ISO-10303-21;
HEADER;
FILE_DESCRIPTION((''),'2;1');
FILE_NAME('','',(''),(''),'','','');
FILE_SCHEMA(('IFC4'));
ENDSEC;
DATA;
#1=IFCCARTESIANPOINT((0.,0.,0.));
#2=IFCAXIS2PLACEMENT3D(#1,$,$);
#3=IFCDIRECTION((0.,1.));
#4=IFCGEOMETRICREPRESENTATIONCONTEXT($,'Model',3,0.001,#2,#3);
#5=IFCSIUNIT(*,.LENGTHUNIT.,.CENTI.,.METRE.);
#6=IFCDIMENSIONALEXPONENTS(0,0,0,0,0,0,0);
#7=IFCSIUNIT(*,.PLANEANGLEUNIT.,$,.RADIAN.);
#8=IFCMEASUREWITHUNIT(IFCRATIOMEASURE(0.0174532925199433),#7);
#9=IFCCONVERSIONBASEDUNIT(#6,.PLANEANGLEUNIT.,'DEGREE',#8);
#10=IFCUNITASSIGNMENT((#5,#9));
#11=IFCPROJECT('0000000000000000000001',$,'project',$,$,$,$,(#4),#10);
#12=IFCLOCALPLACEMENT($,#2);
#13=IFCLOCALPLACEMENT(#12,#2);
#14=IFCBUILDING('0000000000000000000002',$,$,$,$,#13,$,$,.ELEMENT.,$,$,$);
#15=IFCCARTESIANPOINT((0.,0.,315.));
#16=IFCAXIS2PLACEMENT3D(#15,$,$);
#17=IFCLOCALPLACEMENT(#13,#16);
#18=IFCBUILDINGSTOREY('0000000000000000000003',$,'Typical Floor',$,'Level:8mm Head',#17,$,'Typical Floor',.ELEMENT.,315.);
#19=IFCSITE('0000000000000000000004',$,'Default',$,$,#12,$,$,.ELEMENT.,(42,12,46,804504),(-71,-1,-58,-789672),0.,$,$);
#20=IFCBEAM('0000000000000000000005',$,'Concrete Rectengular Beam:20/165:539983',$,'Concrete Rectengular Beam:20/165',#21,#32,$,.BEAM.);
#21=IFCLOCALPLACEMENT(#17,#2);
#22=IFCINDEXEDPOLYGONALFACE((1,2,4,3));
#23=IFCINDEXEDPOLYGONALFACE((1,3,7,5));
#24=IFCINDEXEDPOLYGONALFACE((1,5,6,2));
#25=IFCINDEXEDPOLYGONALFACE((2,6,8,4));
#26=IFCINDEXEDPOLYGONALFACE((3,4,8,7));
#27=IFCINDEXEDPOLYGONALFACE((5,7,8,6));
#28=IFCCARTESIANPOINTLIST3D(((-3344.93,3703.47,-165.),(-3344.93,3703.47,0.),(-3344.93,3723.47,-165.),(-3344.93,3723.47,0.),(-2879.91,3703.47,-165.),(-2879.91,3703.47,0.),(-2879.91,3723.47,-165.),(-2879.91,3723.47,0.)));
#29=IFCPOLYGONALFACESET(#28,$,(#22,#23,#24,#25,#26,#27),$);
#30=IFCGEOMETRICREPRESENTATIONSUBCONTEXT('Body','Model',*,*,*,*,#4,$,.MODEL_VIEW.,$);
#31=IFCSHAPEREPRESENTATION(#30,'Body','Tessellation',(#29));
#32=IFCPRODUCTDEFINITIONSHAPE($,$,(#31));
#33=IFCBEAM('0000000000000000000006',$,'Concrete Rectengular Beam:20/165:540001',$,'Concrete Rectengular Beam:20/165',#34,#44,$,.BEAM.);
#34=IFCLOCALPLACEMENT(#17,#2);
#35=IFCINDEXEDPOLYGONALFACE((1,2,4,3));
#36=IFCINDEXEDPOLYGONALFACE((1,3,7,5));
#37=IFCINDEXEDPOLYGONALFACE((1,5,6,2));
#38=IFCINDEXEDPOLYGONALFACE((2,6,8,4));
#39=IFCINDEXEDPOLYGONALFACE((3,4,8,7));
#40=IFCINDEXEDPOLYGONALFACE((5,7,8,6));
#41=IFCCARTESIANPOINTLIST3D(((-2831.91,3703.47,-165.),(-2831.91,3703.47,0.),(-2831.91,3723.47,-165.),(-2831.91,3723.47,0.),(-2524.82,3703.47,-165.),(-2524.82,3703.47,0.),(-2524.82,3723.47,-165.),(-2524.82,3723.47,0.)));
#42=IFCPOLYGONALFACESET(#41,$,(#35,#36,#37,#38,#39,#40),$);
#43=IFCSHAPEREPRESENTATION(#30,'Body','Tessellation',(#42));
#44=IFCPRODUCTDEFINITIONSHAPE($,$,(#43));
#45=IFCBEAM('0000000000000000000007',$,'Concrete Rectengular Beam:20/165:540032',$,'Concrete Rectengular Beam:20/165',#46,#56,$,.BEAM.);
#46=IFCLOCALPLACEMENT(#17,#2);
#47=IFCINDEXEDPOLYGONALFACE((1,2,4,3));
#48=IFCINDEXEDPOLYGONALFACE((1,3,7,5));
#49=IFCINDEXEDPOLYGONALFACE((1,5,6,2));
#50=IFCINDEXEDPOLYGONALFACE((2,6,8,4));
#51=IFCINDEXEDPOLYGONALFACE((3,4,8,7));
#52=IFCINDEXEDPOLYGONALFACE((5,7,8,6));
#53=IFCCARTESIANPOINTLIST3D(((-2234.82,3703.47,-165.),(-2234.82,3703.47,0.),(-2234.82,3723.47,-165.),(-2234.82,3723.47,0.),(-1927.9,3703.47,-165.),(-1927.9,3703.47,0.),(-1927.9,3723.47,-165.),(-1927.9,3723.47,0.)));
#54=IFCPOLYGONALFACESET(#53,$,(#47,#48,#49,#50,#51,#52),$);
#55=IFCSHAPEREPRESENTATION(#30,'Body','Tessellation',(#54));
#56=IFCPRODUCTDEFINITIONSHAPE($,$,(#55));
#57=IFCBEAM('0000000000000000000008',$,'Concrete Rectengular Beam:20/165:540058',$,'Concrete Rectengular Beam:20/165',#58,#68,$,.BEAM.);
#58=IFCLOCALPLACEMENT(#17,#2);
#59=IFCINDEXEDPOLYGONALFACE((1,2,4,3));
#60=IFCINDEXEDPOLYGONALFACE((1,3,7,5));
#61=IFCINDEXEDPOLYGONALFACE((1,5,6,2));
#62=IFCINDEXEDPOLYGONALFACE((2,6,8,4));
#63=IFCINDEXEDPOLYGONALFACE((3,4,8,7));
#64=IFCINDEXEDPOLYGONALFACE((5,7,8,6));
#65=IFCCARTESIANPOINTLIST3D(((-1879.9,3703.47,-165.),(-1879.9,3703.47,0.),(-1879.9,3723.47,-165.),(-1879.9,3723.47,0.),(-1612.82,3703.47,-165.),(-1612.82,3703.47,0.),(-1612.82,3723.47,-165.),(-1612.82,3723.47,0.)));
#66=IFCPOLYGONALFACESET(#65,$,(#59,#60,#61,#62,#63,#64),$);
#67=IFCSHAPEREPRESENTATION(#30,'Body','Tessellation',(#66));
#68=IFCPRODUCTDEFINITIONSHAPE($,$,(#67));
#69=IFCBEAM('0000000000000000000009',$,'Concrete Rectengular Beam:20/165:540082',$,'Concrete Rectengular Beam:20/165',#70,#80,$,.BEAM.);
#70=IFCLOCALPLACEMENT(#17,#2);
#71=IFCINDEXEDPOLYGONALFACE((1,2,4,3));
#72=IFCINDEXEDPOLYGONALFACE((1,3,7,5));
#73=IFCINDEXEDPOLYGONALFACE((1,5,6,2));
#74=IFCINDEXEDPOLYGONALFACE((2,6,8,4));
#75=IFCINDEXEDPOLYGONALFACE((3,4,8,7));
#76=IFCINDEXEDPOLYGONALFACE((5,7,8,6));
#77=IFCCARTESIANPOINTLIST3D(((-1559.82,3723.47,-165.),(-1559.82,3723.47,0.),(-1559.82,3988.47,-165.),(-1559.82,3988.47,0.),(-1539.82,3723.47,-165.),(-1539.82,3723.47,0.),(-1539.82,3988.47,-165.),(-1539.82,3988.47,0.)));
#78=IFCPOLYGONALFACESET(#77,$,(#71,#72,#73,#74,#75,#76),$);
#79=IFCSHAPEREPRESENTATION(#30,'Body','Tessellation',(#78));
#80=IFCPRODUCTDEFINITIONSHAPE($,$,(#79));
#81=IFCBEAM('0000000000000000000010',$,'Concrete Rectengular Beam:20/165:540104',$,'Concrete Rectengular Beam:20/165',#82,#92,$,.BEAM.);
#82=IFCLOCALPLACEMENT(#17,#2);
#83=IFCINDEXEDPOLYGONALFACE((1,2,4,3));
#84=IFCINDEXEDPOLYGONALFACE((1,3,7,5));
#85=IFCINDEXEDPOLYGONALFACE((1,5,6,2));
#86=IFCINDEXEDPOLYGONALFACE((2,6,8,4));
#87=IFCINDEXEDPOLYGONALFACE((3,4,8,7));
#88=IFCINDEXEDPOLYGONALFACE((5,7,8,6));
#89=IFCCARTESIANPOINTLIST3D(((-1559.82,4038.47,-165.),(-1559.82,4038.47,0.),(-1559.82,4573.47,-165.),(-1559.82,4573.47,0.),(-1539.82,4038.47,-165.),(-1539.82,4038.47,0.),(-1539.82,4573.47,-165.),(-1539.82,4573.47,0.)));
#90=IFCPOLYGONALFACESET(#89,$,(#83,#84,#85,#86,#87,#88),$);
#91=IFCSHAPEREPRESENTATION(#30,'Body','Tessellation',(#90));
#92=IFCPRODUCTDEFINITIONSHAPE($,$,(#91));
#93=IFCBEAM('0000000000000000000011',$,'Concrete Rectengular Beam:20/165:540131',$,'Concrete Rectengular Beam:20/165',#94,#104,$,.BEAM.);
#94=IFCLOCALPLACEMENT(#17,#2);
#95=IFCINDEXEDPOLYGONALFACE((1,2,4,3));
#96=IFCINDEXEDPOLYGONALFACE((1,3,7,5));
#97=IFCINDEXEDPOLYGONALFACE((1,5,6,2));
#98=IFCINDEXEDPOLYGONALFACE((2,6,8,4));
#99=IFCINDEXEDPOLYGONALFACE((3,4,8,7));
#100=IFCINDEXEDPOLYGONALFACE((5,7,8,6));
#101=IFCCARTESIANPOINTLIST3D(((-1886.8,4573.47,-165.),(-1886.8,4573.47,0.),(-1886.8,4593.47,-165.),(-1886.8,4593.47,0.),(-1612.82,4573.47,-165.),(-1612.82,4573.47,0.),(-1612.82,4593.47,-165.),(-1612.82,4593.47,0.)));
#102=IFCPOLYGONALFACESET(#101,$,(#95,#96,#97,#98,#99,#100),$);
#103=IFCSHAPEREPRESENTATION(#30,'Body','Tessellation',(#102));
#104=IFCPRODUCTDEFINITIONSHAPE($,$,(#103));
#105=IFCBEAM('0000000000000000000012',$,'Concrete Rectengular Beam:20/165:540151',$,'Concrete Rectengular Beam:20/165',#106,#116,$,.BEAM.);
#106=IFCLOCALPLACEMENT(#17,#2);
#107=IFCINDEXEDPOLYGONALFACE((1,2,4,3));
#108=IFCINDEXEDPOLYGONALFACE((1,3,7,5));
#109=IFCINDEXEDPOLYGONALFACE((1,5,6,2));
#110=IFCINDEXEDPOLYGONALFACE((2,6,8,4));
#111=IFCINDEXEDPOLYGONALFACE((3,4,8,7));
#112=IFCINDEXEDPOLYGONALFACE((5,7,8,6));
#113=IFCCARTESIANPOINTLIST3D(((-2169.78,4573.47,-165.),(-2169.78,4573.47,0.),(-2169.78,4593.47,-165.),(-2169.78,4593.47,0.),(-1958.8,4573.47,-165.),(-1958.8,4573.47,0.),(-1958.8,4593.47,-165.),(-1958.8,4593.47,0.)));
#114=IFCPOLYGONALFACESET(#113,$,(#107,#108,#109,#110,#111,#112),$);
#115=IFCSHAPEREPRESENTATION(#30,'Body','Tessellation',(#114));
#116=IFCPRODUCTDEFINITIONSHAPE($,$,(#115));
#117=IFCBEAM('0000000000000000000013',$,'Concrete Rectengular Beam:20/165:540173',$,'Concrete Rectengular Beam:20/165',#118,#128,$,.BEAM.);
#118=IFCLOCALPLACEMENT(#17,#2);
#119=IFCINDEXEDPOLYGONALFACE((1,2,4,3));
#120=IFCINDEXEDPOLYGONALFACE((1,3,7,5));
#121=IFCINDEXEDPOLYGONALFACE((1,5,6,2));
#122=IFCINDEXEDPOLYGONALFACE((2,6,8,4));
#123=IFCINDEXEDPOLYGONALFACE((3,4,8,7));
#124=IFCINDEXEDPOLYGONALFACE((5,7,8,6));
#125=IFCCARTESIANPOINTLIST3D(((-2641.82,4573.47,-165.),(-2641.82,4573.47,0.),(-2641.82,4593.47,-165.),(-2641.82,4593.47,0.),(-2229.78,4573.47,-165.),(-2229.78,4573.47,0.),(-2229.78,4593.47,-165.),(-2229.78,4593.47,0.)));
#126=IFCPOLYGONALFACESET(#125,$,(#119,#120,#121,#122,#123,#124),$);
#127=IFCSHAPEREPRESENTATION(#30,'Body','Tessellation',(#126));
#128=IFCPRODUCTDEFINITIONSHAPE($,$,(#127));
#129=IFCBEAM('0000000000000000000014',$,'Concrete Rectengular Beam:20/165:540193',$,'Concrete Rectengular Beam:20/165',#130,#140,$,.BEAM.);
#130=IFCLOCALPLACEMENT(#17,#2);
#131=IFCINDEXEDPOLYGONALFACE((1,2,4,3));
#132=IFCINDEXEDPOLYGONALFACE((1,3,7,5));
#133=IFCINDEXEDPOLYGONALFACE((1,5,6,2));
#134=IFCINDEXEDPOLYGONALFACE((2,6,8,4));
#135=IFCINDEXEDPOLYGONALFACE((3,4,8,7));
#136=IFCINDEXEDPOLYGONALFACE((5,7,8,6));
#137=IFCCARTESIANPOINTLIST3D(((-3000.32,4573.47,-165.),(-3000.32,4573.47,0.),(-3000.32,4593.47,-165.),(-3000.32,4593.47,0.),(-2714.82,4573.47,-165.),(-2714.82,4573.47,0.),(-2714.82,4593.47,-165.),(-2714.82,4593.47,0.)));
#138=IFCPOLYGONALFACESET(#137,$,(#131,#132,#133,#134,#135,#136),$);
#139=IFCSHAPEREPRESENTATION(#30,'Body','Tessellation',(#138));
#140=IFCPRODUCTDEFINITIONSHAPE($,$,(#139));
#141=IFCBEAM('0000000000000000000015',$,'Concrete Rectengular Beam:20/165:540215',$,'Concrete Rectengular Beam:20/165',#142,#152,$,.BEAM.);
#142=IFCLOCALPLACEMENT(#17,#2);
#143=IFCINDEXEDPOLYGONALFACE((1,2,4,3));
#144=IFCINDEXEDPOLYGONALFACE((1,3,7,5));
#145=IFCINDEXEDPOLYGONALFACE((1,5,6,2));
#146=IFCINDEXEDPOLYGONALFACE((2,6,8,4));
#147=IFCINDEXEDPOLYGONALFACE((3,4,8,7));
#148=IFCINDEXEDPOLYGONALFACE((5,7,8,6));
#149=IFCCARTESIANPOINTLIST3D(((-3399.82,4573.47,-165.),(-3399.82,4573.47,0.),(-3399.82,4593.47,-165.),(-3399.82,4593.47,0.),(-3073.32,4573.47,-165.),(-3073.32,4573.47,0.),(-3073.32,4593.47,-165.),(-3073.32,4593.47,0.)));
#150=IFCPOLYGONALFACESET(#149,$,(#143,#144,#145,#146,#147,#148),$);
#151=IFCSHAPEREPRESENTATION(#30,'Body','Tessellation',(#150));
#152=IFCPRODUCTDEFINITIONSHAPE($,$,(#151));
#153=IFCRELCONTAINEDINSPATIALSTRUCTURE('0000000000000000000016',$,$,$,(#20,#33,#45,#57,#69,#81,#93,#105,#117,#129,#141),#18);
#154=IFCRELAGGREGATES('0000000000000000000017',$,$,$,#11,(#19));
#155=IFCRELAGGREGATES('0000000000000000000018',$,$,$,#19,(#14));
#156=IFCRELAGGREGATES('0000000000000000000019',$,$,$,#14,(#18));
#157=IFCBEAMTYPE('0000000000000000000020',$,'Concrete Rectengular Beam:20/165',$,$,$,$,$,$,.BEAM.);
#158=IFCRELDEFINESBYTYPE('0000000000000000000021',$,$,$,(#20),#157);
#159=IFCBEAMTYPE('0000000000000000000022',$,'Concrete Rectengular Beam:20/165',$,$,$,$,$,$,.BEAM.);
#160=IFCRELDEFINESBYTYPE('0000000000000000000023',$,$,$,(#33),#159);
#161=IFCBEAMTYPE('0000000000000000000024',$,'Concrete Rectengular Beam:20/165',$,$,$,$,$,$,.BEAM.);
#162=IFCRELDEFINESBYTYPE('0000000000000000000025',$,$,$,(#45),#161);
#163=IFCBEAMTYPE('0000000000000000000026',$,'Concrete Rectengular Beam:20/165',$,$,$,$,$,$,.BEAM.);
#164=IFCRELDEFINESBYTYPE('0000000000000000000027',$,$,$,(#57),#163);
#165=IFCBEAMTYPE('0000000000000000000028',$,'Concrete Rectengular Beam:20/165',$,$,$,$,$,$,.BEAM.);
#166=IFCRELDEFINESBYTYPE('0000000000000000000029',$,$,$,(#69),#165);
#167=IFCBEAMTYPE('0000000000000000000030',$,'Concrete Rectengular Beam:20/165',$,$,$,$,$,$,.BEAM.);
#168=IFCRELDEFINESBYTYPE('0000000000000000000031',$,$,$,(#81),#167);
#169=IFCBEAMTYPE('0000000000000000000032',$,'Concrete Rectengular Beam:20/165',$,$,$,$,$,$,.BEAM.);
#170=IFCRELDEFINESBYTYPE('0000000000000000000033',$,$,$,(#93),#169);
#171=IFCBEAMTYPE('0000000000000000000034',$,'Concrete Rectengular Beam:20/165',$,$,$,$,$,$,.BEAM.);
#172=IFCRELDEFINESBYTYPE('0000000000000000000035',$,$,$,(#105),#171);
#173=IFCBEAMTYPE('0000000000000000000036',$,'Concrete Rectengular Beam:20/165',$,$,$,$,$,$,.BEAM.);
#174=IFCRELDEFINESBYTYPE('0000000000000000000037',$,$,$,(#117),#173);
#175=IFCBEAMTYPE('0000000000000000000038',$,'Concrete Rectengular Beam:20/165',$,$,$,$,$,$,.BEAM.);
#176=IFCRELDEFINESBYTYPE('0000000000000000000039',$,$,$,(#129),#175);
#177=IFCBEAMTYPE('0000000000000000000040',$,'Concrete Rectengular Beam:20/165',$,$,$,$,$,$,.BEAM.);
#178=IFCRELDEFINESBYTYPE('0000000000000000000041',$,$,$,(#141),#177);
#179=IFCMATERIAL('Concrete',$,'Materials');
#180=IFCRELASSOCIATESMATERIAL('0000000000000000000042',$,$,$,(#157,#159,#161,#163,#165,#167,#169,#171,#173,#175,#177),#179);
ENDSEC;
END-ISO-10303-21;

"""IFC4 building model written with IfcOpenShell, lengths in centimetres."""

from ifc_helpers import new_model, entity, si_unit, converted_unit, direction, frame, origin, place, context, subcontext, project, spatial, indexed_curve, outline, extrude, source, transform, mapped, material, type_object, type_shapes, element, save


model = new_model("IFC4")

# Units and contexts
model_context = context("Model", 3, precision=0.001, world=origin(), true_north=direction((0.0, 1.0)))
body_context = subcontext(model_context, "Body", "Model", "MODEL_VIEW")
ifc_project = project(units=[si_unit("LENGTHUNIT", "METRE", prefix="CENTI"), converted_unit("PLANEANGLEUNIT", "DEGREE", entity("IfcRatioMeasure", 0.0174532925199433), si_unit("PLANEANGLEUNIT", "RADIAN"), dimensions=[0, 0, 0, 0, 0, 0, 0])], contexts=[model_context])

# Site, building, storey
site_placement = place(None, origin())
site = spatial("IfcSite", under=ifc_project, at=site_placement, Name="Default", CompositionType="ELEMENT", RefLatitude=(42, 12, 46, 804504), RefLongitude=(-71, -1, -58, -789672), RefElevation=0.0)
building_placement = place(site_placement, origin())
building = spatial("IfcBuilding", under=site, at=building_placement, CompositionType="ELEMENT")
storey_placement = place(building_placement, frame((0.0, 0.0, 315.0)))
storey = spatial("IfcBuildingStorey", under=building, at=storey_placement, Name="Typical Floor", ObjectType="Level:8mm Head", LongName="Typical Floor", CompositionType="ELEMENT", Elevation=315.0)

# Beams
ifc_material = material(Name="Concrete", Category="Materials")
beam_type_1 = type_object("IfcBeamType", Name="Concrete Rectengular Beam:20/165", PredefinedType="BEAM", material=ifc_material)
shared_shape_1 = source(origin(), body_context, "Body", "SweptSolid", [
    extrude(outline(indexed_curve([(-82.5, -10.0), (82.5, -10.0), (82.5, 10.0), (-82.5, 10.0), (-82.5, -10.0)], self_intersect=False)), frame((-3344.93, 3713.47, 232.5), z_axis=(1.0, 0.0, 0.0), x_axis=(0.0, 0.0, -1.0)), (0.0, 0.0, 1.0), 465.02),
])
type_shapes(beam_type_1, [shared_shape_1])
beam_1_placement = place(storey_placement, frame((0.0, 0.0, -315.0)))
element("IfcBeam", 1, at=beam_1_placement, inside=storey, type_object=beam_type_1, Name="Concrete Rectengular Beam:20/165:539983", ObjectType="Concrete Rectengular Beam:20/165", PredefinedType="BEAM", context=body_context, shape_type="MappedRepresentation", body=[
    mapped(shared_shape_1, transform((0.0, 0.0, 0.0), scale=1.0)),
])
beam_type_2 = type_object("IfcBeamType", Name="Concrete Rectengular Beam:20/165", PredefinedType="BEAM", material=ifc_material)
shared_shape_2 = source(origin(), body_context, "Body", "SweptSolid", [
    extrude(outline(indexed_curve([(-82.5, -10.0), (82.5, -10.0), (82.5, 10.0), (-82.5, 10.0), (-82.5, -10.0)], self_intersect=False)), frame((-2831.91, 3713.47, 232.5), z_axis=(1.0, 0.0, 0.0), x_axis=(0.0, 0.0, -1.0)), (0.0, 0.0, 1.0), 307.09),
])
type_shapes(beam_type_2, [shared_shape_2])
beam_2_placement = place(storey_placement, frame((0.0, 0.0, -315.0)))
element("IfcBeam", 2, at=beam_2_placement, inside=storey, type_object=beam_type_2, Name="Concrete Rectengular Beam:20/165:540001", ObjectType="Concrete Rectengular Beam:20/165", PredefinedType="BEAM", context=body_context, shape_type="MappedRepresentation", body=[
    mapped(shared_shape_2, transform((0.0, 0.0, 0.0), scale=1.0)),
])
beam_type_3 = type_object("IfcBeamType", Name="Concrete Rectengular Beam:20/165", PredefinedType="BEAM", material=ifc_material)
shared_shape_3 = source(origin(), body_context, "Body", "SweptSolid", [
    extrude(outline(indexed_curve([(-82.5, -10.0), (82.5, -10.0), (82.5, 10.0), (-82.5, 10.0), (-82.5, -10.0)], self_intersect=False)), frame((-2234.82, 3713.47, 232.5), z_axis=(1.0, 0.0, 0.0), x_axis=(0.0, 0.0, -1.0)), (0.0, 0.0, 1.0), 306.92),
])
type_shapes(beam_type_3, [shared_shape_3])
beam_3_placement = place(storey_placement, frame((0.0, 0.0, -315.0)))
element("IfcBeam", 3, at=beam_3_placement, inside=storey, type_object=beam_type_3, Name="Concrete Rectengular Beam:20/165:540032", ObjectType="Concrete Rectengular Beam:20/165", PredefinedType="BEAM", context=body_context, shape_type="MappedRepresentation", body=[
    mapped(shared_shape_3, transform((0.0, 0.0, 0.0), scale=1.0)),
])
beam_type_4 = type_object("IfcBeamType", Name="Concrete Rectengular Beam:20/165", PredefinedType="BEAM", material=ifc_material)
shared_shape_4 = source(origin(), body_context, "Body", "SweptSolid", [
    extrude(outline(indexed_curve([(-82.5, -10.0), (82.5, -10.0), (82.5, 10.0), (-82.5, 10.0), (-82.5, -10.0)], self_intersect=False)), frame((-1879.9, 3713.47, 232.5), z_axis=(1.0, 0.0, 0.0), x_axis=(0.0, 0.0, -1.0)), (0.0, 0.0, 1.0), 267.08),
])
type_shapes(beam_type_4, [shared_shape_4])
beam_4_placement = place(storey_placement, frame((0.0, 0.0, -315.0)))
element("IfcBeam", 4, at=beam_4_placement, inside=storey, type_object=beam_type_4, Name="Concrete Rectengular Beam:20/165:540058", ObjectType="Concrete Rectengular Beam:20/165", PredefinedType="BEAM", context=body_context, shape_type="MappedRepresentation", body=[
    mapped(shared_shape_4, transform((0.0, 0.0, 0.0), scale=1.0)),
])
beam_type_5 = type_object("IfcBeamType", Name="Concrete Rectengular Beam:20/165", PredefinedType="BEAM", material=ifc_material)
shared_shape_5 = source(origin(), body_context, "Body", "SweptSolid", [
    extrude(outline(indexed_curve([(-10.0, -82.5), (10.0, -82.5), (10.0, 82.5), (-10.0, 82.5), (-10.0, -82.5)], self_intersect=False)), frame((-1549.82, 3723.47, 232.5), z_axis=(0.0, 1.0, 0.0), x_axis=(-1.0, 0.0, 0.0)), (0.0, 0.0, 1.0), 265.0),
])
type_shapes(beam_type_5, [shared_shape_5])
beam_5_placement = place(storey_placement, frame((0.0, 0.0, -315.0)))
element("IfcBeam", 5, at=beam_5_placement, inside=storey, type_object=beam_type_5, Name="Concrete Rectengular Beam:20/165:540082", ObjectType="Concrete Rectengular Beam:20/165", PredefinedType="BEAM", context=body_context, shape_type="MappedRepresentation", body=[
    mapped(shared_shape_5, transform((0.0, 0.0, 0.0), scale=1.0)),
])
beam_type_6 = type_object("IfcBeamType", Name="Concrete Rectengular Beam:20/165", PredefinedType="BEAM", material=ifc_material)
shared_shape_6 = source(origin(), body_context, "Body", "SweptSolid", [
    extrude(outline(indexed_curve([(-10.0, -82.5), (10.0, -82.5), (10.0, 82.5), (-10.0, 82.5), (-10.0, -82.5)], self_intersect=False)), frame((-1549.82, 4038.47, 232.5), z_axis=(0.0, 1.0, 0.0), x_axis=(-1.0, 0.0, 0.0)), (0.0, 0.0, 1.0), 535.0),
])
type_shapes(beam_type_6, [shared_shape_6])
beam_6_placement = place(storey_placement, frame((0.0, 0.0, -315.0)))
element("IfcBeam", 6, at=beam_6_placement, inside=storey, type_object=beam_type_6, Name="Concrete Rectengular Beam:20/165:540104", ObjectType="Concrete Rectengular Beam:20/165", PredefinedType="BEAM", context=body_context, shape_type="MappedRepresentation", body=[
    mapped(shared_shape_6, transform((0.0, 0.0, 0.0), scale=1.0)),
])
beam_type_7 = type_object("IfcBeamType", Name="Concrete Rectengular Beam:20/165", PredefinedType="BEAM", material=ifc_material)
shared_shape_7 = source(origin(), body_context, "Body", "SweptSolid", [
    extrude(outline(indexed_curve([(-82.5, -10.0), (82.5, -10.0), (82.5, 10.0), (-82.5, 10.0), (-82.5, -10.0)], self_intersect=False)), frame((-1612.82, 4583.47, 232.5), z_axis=(-1.0, 0.0, 0.0), x_axis=(0.0, 0.0, -1.0)), (0.0, 0.0, 1.0), 273.98),
])
type_shapes(beam_type_7, [shared_shape_7])
beam_7_placement = place(storey_placement, frame((0.0, 0.0, -315.0)))
element("IfcBeam", 7, at=beam_7_placement, inside=storey, type_object=beam_type_7, Name="Concrete Rectengular Beam:20/165:540131", ObjectType="Concrete Rectengular Beam:20/165", PredefinedType="BEAM", context=body_context, shape_type="MappedRepresentation", body=[
    mapped(shared_shape_7, transform((0.0, 0.0, 0.0), scale=1.0)),
])
beam_type_8 = type_object("IfcBeamType", Name="Concrete Rectengular Beam:20/165", PredefinedType="BEAM", material=ifc_material)
shared_shape_8 = source(origin(), body_context, "Body", "SweptSolid", [
    extrude(outline(indexed_curve([(-82.5, -10.0), (82.5, -10.0), (82.5, 10.0), (-82.5, 10.0), (-82.5, -10.0)], self_intersect=False)), frame((-1958.8, 4583.47, 232.5), z_axis=(-1.0, 0.0, 0.0), x_axis=(0.0, 0.0, -1.0)), (0.0, 0.0, 1.0), 210.98),
])
type_shapes(beam_type_8, [shared_shape_8])
beam_8_placement = place(storey_placement, frame((0.0, 0.0, -315.0)))
element("IfcBeam", 8, at=beam_8_placement, inside=storey, type_object=beam_type_8, Name="Concrete Rectengular Beam:20/165:540151", ObjectType="Concrete Rectengular Beam:20/165", PredefinedType="BEAM", context=body_context, shape_type="MappedRepresentation", body=[
    mapped(shared_shape_8, transform((0.0, 0.0, 0.0), scale=1.0)),
])
beam_type_9 = type_object("IfcBeamType", Name="Concrete Rectengular Beam:20/165", PredefinedType="BEAM", material=ifc_material)
shared_shape_9 = source(origin(), body_context, "Body", "SweptSolid", [
    extrude(outline(indexed_curve([(-82.5, -10.0), (82.5, -10.0), (82.5, 10.0), (-82.5, 10.0), (-82.5, -10.0)], self_intersect=False)), frame((-2229.78, 4583.47, 232.5), z_axis=(-1.0, 0.0, 0.0), x_axis=(0.0, 0.0, -1.0)), (0.0, 0.0, 1.0), 412.04),
])
type_shapes(beam_type_9, [shared_shape_9])
beam_9_placement = place(storey_placement, frame((0.0, 0.0, -315.0)))
element("IfcBeam", 9, at=beam_9_placement, inside=storey, type_object=beam_type_9, Name="Concrete Rectengular Beam:20/165:540173", ObjectType="Concrete Rectengular Beam:20/165", PredefinedType="BEAM", context=body_context, shape_type="MappedRepresentation", body=[
    mapped(shared_shape_9, transform((0.0, 0.0, 0.0), scale=1.0)),
])
beam_type_10 = type_object("IfcBeamType", Name="Concrete Rectengular Beam:20/165", PredefinedType="BEAM", material=ifc_material)
shared_shape_10 = source(origin(), body_context, "Body", "SweptSolid", [
    extrude(outline(indexed_curve([(-82.5, -10.0), (82.5, -10.0), (82.5, 10.0), (-82.5, 10.0), (-82.5, -10.0)], self_intersect=False)), frame((-2714.82, 4583.47, 232.5), z_axis=(-1.0, 0.0, 0.0), x_axis=(0.0, 0.0, -1.0)), (0.0, 0.0, 1.0), 285.5),
])
type_shapes(beam_type_10, [shared_shape_10])
beam_10_placement = place(storey_placement, frame((0.0, 0.0, -315.0)))
element("IfcBeam", 10, at=beam_10_placement, inside=storey, type_object=beam_type_10, Name="Concrete Rectengular Beam:20/165:540193", ObjectType="Concrete Rectengular Beam:20/165", PredefinedType="BEAM", context=body_context, shape_type="MappedRepresentation", body=[
    mapped(shared_shape_10, transform((0.0, 0.0, 0.0), scale=1.0)),
])
beam_type_11 = type_object("IfcBeamType", Name="Concrete Rectengular Beam:20/165", PredefinedType="BEAM", material=ifc_material)
shared_shape_11 = source(origin(), body_context, "Body", "SweptSolid", [
    extrude(outline(indexed_curve([(-82.5, -10.0), (82.5, -10.0), (82.5, 10.0), (-82.5, 10.0), (-82.5, -10.0)], self_intersect=False)), frame((-3073.32, 4583.47, 232.5), z_axis=(-1.0, 0.0, 0.0), x_axis=(0.0, 0.0, -1.0)), (0.0, 0.0, 1.0), 326.5),
])
type_shapes(beam_type_11, [shared_shape_11])
beam_11_placement = place(storey_placement, frame((0.0, 0.0, -315.0)))
element("IfcBeam", 11, at=beam_11_placement, inside=storey, type_object=beam_type_11, Name="Concrete Rectengular Beam:20/165:540215", ObjectType="Concrete Rectengular Beam:20/165", PredefinedType="BEAM", context=body_context, shape_type="MappedRepresentation", body=[
    mapped(shared_shape_11, transform((0.0, 0.0, 0.0), scale=1.0)),
])

save(model, "model.ifc")
